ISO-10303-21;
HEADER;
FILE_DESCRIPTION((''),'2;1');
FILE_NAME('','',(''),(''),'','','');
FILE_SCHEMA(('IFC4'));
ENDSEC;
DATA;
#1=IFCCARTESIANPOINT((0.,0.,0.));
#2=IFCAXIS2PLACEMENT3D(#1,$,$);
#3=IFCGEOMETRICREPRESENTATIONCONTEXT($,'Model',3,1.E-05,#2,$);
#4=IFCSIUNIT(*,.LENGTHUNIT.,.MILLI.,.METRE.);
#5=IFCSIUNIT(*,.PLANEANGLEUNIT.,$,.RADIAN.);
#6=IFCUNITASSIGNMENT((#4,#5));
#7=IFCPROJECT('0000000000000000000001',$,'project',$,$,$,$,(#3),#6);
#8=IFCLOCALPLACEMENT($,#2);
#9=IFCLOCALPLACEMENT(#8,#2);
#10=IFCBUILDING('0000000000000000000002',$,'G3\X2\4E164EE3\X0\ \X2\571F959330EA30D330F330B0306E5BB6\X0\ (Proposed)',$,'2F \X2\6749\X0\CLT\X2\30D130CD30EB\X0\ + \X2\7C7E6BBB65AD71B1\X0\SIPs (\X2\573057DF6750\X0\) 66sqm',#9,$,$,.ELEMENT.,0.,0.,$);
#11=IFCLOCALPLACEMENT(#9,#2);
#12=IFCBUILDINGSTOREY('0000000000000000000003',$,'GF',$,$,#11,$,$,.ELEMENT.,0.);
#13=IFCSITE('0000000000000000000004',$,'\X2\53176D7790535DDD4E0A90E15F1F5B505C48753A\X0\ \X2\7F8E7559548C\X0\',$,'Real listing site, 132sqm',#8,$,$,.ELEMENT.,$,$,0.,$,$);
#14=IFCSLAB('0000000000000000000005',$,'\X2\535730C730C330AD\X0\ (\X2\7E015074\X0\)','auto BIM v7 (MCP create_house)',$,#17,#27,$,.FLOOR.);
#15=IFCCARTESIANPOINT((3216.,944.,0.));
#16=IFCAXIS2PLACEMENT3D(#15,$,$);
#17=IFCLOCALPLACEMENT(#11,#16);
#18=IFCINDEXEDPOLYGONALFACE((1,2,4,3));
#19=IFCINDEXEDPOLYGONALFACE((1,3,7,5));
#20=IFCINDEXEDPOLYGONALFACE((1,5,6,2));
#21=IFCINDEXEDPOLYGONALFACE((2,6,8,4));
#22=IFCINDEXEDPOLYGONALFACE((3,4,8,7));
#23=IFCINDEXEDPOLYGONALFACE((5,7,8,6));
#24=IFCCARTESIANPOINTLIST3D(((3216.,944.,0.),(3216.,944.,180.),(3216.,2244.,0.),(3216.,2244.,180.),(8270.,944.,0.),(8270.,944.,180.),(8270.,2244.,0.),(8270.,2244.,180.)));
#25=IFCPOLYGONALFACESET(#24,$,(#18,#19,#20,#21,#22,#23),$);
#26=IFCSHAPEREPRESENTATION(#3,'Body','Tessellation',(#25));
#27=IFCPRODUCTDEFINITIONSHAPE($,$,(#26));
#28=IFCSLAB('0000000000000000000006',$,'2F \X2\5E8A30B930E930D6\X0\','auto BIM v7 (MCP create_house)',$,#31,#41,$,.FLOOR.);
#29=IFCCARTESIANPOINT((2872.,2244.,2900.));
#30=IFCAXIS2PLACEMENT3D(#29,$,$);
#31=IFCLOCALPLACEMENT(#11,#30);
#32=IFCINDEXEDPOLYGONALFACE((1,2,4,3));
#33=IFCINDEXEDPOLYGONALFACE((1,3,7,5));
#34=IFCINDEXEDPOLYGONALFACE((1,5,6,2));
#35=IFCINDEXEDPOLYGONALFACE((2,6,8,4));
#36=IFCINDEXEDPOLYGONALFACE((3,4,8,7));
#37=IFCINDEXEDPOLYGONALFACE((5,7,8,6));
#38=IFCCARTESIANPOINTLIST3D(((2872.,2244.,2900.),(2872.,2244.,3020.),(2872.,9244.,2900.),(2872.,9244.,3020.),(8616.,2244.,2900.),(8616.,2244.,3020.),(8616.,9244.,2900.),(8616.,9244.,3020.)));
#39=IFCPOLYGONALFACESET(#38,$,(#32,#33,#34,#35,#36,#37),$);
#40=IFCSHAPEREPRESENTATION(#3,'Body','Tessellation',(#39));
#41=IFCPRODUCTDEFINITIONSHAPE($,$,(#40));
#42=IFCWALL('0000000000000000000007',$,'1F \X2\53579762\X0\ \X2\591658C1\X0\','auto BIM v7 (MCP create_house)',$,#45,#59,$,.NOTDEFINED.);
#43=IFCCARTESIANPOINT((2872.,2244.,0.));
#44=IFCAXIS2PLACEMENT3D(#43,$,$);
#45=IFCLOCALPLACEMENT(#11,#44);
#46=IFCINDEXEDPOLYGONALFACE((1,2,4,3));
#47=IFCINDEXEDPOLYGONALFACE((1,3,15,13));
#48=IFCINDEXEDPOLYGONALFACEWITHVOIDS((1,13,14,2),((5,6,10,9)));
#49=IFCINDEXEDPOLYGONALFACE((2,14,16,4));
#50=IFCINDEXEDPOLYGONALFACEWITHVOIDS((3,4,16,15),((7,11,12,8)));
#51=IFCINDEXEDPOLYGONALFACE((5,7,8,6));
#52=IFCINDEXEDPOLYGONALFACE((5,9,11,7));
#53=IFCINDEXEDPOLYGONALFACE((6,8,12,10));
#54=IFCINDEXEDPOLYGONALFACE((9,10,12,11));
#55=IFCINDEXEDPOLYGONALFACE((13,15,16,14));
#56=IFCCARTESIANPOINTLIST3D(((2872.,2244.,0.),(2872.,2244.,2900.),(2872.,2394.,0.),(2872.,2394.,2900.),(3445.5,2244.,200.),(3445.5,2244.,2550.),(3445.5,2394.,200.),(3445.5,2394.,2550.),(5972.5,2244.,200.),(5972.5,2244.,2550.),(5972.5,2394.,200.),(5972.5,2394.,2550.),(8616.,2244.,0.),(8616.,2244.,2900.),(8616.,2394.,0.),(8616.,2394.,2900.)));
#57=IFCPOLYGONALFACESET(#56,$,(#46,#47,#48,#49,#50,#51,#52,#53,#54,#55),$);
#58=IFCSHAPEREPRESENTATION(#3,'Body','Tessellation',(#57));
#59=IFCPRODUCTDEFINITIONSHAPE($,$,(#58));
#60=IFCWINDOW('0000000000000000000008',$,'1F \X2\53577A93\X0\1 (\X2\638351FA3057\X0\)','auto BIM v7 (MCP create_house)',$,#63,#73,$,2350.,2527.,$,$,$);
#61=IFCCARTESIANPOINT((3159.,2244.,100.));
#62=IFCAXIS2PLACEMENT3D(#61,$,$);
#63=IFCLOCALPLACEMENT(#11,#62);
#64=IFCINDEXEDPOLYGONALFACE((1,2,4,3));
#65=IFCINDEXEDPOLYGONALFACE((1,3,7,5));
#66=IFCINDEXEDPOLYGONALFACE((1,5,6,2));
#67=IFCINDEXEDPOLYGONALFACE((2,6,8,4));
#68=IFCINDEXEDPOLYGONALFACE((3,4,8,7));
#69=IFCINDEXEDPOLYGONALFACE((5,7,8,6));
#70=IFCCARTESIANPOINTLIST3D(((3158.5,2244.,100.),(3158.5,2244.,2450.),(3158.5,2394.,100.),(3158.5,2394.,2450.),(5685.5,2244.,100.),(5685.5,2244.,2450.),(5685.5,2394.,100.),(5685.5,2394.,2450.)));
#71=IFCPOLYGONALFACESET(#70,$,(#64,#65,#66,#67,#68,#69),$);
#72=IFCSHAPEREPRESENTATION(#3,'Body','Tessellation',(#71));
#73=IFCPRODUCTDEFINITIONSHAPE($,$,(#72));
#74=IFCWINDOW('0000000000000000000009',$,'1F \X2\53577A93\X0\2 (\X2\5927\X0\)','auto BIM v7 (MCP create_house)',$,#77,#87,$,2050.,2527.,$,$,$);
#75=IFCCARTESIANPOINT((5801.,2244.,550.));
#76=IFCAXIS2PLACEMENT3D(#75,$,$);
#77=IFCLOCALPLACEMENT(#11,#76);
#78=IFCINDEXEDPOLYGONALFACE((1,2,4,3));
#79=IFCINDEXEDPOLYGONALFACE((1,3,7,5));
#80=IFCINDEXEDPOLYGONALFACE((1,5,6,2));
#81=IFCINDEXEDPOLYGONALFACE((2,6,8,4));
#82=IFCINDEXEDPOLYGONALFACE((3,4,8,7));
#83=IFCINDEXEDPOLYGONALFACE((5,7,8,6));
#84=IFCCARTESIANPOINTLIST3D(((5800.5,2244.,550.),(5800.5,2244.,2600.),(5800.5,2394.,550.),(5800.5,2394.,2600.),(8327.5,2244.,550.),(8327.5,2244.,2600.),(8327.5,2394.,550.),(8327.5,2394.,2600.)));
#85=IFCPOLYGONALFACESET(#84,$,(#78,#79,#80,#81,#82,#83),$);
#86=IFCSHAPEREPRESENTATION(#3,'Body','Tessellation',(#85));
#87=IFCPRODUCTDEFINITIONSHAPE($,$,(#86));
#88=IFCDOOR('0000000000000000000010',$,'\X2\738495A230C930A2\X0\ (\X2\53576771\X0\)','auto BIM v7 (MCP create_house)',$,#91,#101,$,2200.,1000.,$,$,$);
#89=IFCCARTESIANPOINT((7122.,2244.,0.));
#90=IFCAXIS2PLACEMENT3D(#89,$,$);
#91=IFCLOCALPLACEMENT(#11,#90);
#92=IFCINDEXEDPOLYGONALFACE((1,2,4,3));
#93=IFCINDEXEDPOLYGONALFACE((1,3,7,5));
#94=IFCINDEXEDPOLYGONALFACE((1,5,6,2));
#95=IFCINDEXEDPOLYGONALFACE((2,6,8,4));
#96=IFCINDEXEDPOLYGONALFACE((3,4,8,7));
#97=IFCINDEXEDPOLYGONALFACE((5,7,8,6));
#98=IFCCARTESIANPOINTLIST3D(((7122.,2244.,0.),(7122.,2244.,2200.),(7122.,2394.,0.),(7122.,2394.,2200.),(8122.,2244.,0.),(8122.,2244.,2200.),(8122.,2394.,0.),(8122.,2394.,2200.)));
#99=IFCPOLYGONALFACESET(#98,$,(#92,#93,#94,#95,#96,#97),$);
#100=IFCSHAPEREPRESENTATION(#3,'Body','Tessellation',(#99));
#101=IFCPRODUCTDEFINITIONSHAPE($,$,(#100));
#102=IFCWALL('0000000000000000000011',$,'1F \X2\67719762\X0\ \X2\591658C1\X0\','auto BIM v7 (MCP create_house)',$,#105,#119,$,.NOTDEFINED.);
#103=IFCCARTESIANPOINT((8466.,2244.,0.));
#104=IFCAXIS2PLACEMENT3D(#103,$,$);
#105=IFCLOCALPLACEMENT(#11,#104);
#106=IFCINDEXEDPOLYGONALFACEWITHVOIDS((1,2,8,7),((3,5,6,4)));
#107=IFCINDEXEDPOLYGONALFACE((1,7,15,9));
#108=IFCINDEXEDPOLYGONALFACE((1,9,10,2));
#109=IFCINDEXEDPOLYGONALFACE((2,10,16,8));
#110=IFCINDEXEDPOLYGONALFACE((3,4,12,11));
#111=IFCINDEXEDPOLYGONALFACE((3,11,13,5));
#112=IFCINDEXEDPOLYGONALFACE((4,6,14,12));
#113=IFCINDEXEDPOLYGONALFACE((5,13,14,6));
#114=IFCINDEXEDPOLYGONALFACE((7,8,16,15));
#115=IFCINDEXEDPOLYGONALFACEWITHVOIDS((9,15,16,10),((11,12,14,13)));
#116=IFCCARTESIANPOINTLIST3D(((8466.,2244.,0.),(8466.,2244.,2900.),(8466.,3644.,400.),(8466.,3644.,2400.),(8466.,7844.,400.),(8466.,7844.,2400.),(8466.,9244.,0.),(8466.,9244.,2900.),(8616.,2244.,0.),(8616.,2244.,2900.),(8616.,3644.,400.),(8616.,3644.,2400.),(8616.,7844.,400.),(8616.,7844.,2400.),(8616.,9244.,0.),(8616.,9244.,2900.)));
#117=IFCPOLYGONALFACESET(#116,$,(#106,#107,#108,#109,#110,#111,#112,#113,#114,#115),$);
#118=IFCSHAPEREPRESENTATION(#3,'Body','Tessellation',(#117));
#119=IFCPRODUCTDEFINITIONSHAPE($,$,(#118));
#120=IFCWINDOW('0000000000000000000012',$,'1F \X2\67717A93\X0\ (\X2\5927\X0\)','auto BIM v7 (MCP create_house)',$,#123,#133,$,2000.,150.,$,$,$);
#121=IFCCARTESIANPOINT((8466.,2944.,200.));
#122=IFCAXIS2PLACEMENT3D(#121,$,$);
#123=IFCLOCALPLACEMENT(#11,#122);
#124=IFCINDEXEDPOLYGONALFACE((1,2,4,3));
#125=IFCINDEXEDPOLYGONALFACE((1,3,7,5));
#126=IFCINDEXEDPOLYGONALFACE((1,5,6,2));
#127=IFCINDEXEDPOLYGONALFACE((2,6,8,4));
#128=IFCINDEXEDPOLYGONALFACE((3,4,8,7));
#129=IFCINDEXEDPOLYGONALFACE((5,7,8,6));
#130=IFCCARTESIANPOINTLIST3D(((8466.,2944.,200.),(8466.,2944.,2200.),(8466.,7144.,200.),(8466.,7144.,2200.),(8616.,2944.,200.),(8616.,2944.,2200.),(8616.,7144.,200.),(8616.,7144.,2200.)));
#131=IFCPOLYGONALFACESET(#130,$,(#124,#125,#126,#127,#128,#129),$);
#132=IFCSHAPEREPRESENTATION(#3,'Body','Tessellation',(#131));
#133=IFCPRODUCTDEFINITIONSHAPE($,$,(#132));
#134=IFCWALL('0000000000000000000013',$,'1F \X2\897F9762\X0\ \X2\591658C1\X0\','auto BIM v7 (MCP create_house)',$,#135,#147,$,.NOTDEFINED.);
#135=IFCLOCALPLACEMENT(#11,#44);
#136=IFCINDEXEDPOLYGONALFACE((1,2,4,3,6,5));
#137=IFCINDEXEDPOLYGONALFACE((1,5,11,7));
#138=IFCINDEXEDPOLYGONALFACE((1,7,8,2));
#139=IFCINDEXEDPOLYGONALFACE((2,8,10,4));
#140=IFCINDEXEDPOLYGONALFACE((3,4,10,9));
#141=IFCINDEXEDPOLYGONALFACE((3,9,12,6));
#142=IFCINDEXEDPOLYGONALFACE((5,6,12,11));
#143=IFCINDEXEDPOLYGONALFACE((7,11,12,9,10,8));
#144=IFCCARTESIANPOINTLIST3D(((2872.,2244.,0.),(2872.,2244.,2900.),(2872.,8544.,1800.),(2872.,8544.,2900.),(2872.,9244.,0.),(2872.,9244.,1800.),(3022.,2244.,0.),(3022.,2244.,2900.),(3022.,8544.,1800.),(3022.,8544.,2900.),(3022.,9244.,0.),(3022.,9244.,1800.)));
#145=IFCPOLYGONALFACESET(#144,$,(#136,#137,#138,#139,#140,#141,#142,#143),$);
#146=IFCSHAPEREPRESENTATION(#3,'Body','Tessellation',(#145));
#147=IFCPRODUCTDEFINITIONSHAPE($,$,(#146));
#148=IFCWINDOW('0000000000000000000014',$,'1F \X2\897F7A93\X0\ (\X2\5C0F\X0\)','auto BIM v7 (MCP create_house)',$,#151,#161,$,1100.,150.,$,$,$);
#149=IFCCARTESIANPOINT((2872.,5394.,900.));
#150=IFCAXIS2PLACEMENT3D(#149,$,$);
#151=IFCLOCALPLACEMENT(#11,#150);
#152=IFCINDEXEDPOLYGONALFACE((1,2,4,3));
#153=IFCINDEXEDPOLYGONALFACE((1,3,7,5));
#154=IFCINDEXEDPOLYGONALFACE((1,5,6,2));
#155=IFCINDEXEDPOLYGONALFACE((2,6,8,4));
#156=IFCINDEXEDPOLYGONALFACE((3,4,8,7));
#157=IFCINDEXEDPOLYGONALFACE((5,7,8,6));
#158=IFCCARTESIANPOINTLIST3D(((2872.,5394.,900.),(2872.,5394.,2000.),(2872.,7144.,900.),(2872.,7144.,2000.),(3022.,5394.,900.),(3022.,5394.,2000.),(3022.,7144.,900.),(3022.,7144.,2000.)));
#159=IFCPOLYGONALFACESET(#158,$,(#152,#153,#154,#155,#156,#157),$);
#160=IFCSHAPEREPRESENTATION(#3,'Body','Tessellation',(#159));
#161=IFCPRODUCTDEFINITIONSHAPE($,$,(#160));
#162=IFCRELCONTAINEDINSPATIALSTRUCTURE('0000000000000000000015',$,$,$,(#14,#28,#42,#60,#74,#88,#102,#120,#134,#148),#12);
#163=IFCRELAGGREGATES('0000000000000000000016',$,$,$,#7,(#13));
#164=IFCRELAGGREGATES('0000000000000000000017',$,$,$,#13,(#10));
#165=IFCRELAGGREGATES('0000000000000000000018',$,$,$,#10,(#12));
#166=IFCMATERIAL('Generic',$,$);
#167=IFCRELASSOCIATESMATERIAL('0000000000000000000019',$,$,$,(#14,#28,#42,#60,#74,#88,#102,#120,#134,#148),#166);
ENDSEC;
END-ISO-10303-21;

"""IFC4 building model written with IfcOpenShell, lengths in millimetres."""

from ifc_helpers import new_model, si_unit, frame, frame_2d, origin, place, context, project, spatial, rectangle, extrude, material, element, fill, save


model = new_model("IFC4")

# Units and contexts
model_context = context("Model", 3, precision=1e-05, world=origin())
ifc_project = project(units=[si_unit("LENGTHUNIT", "METRE", prefix="MILLI"), si_unit("PLANEANGLEUNIT", "RADIAN")], contexts=[model_context])

# Site, building, storey
site_placement = place(None, origin())
site = spatial("IfcSite", under=ifc_project, at=site_placement, Name="北海道川上郡弟子屈町 美留和", ObjectType="Real listing site, 132sqm", CompositionType="ELEMENT", RefElevation=0.0)
building_placement = place(site_placement, origin())
building = spatial("IfcBuilding", under=site, at=building_placement, Name="G3世代 土間リビングの家 (Proposed)", ObjectType="2F 杉CLTパネル + 籾殻断熱SIPs (地域材) 66sqm", CompositionType="ELEMENT", ElevationOfRefHeight=0.0, ElevationOfTerrain=0.0)
storey_placement = place(building_placement, origin())
storey = spatial("IfcBuildingStorey", under=building, at=storey_placement, Name="GF", CompositionType="ELEMENT", Elevation=0.0)

# Slabs
ifc_material = material(Name="Generic")
slab_1_placement = place(storey_placement, frame((3216.0, 944.0, 0.0)))
element("IfcSlab", 1, at=slab_1_placement, inside=storey, material=ifc_material, Name="南デッキ (縁側)", Description="auto BIM v7 (MCP create_house)", PredefinedType="FLOOR", context=model_context, shape_type="SweptSolid", body=[
    extrude(rectangle(XDim=5054.0, YDim=1300.0, at=frame_2d((2527.0, 650.0))), frame((3216.0, 944.0, 0.0)), (0.0, 0.0, 1.0), 180.0),
])
slab_2_placement = place(storey_placement, frame((2872.0, 2244.0, 2900.0)))
element("IfcSlab", 2, at=slab_2_placement, inside=storey, material=ifc_material, Name="2F 床スラブ", Description="auto BIM v7 (MCP create_house)", PredefinedType="FLOOR", context=model_context, shape_type="SweptSolid", body=[
    extrude(rectangle(XDim=5744.0, YDim=7000.0, at=frame_2d((2872.0, 3500.0))), frame((2872.0, 2244.0, 2900.0)), (0.0, 0.0, 1.0), 120.0),
])

# Wall, openings, windows, door
wall_1_placement = place(storey_placement, frame((2872.0, 2244.0, 0.0)))
wall_1 = element("IfcWall", 3, at=wall_1_placement, inside=storey, material=ifc_material, Name="1F 南面 外壁", Description="auto BIM v7 (MCP create_house)", PredefinedType="NOTDEFINED", context=model_context, shape_type="SweptSolid", body=[
    extrude(rectangle(XDim=5744.0, YDim=150.0, at=frame_2d((2872.0, 75.0))), frame((2872.0, 2244.0, 0.0)), (0.0, 0.0, 1.0), 2900.0),
])
opening_1_placement = place(storey_placement, frame((3159.0, 2244.0, 100.0)))
opening_1 = element("IfcOpeningElement", 4, at=opening_1_placement, cuts=wall_1, PredefinedType="NOTDEFINED", context=model_context, shape_type="SweptSolid", body=[
    extrude(rectangle(XDim=2527.0, YDim=150.0, at=frame_2d((1263.0, 75.0))), frame((3159.0, 2244.0, 100.0)), (0.0, 0.0, 1.0), 2350.0),
])
opening_2_placement = place(storey_placement, frame((5801.0, 2244.0, 550.0)))
opening_2 = element("IfcOpeningElement", 5, at=opening_2_placement, cuts=wall_1, PredefinedType="NOTDEFINED", context=model_context, shape_type="SweptSolid", body=[
    extrude(rectangle(XDim=2527.0, YDim=150.0, at=frame_2d((1263.0, 75.0))), frame((5801.0, 2244.0, 550.0)), (0.0, 0.0, 1.0), 2050.0),
])
opening_3_placement = place(storey_placement, frame((7122.0, 2244.0, 0.0)))
opening_3 = element("IfcOpeningElement", 6, at=opening_3_placement, cuts=wall_1, PredefinedType="NOTDEFINED", context=model_context, shape_type="SweptSolid", body=[
    extrude(rectangle(XDim=1000.0, YDim=150.0, at=frame_2d((500.0, 75.0))), frame((7122.0, 2244.0, 0.0)), (0.0, 0.0, 1.0), 2200.0),
])
window_1_placement = place(storey_placement, frame((3159.0, 2244.0, 100.0)))
window_1 = element("IfcWindow", 7, at=window_1_placement, inside=storey, material=ifc_material, Name="1F 南窓1 (掃出し)", Description="auto BIM v7 (MCP create_house)", OverallHeight=2350.0, OverallWidth=2527.0, context=model_context, shape_type="SweptSolid", body=[
    extrude(rectangle(XDim=2527.0, YDim=150.0, at=frame_2d((1263.0, 75.0))), frame((3159.0, 2244.0, 100.0)), (0.0, 0.0, 1.0), 2350.0),
])
fill(opening_1, window_1)
window_2_placement = place(storey_placement, frame((5801.0, 2244.0, 550.0)))
window_2 = element("IfcWindow", 8, at=window_2_placement, inside=storey, material=ifc_material, Name="1F 南窓2 (大)", Description="auto BIM v7 (MCP create_house)", OverallHeight=2050.0, OverallWidth=2527.0, context=model_context, shape_type="SweptSolid", body=[
    extrude(rectangle(XDim=2527.0, YDim=150.0, at=frame_2d((1263.0, 75.0))), frame((5801.0, 2244.0, 550.0)), (0.0, 0.0, 1.0), 2050.0),
])
fill(opening_2, window_2)
door_placement = place(storey_placement, frame((7122.0, 2244.0, 0.0)))
door = element("IfcDoor", 9, at=door_placement, inside=storey, material=ifc_material, Name="玄関ドア (南東)", Description="auto BIM v7 (MCP create_house)", OverallHeight=2200.0, OverallWidth=1000.0, context=model_context, shape_type="SweptSolid", body=[
    extrude(rectangle(XDim=1000.0, YDim=150.0, at=frame_2d((500.0, 75.0))), frame((7122.0, 2244.0, 0.0)), (0.0, 0.0, 1.0), 2200.0),
])
fill(opening_3, door)

# Walls, openings, windows
wall_2_placement = place(storey_placement, frame((8466.0, 2244.0, 0.0)))
wall_2 = element("IfcWall", 10, at=wall_2_placement, inside=storey, material=ifc_material, Name="1F 東面 外壁", Description="auto BIM v7 (MCP create_house)", PredefinedType="NOTDEFINED", context=model_context, shape_type="SweptSolid", body=[
    extrude(rectangle(XDim=150.0, YDim=7000.0, at=frame_2d((75.0, 3500.0))), frame((8466.0, 2244.0, 0.0)), (0.0, 0.0, 1.0), 2900.0),
])
opening_4_placement = place(storey_placement, frame((8466.0, 2944.0, 200.0)))
opening_4 = element("IfcOpeningElement", 11, at=opening_4_placement, cuts=wall_2, PredefinedType="NOTDEFINED", context=model_context, shape_type="SweptSolid", body=[
    extrude(rectangle(XDim=150.0, YDim=4200.0, at=frame_2d((75.0, 2100.0))), frame((8466.0, 2944.0, 200.0)), (0.0, 0.0, 1.0), 2000.0),
])
window_3_placement = place(storey_placement, frame((8466.0, 2944.0, 200.0)))
window_3 = element("IfcWindow", 12, at=window_3_placement, inside=storey, material=ifc_material, Name="1F 東窓 (大)", Description="auto BIM v7 (MCP create_house)", OverallHeight=2000.0, OverallWidth=150.0, context=model_context, shape_type="SweptSolid", body=[
    extrude(rectangle(XDim=150.0, YDim=4200.0, at=frame_2d((75.0, 2100.0))), frame((8466.0, 2944.0, 200.0)), (0.0, 0.0, 1.0), 2000.0),
])
fill(opening_4, window_3)
wall_3_placement = place(storey_placement, frame((2872.0, 2244.0, 0.0)))
wall_3 = element("IfcWall", 13, at=wall_3_placement, inside=storey, material=ifc_material, Name="1F 西面 外壁", Description="auto BIM v7 (MCP create_house)", PredefinedType="NOTDEFINED", context=model_context, shape_type="SweptSolid", body=[
    extrude(rectangle(XDim=150.0, YDim=7000.0, at=frame_2d((75.0, 3500.0))), frame((2872.0, 2244.0, 0.0)), (0.0, 0.0, 1.0), 2900.0),
])
opening_5_placement = place(storey_placement, frame((2872.0, 5394.0, 900.0)))
opening_5 = element("IfcOpeningElement", 14, at=opening_5_placement, cuts=wall_3, PredefinedType="NOTDEFINED", context=model_context, shape_type="SweptSolid", body=[
    extrude(rectangle(XDim=150.0, YDim=1750.0, at=frame_2d((75.0, 875.0))), frame((2872.0, 5394.0, 900.0)), (0.0, 0.0, 1.0), 1100.0),
])
window_4_placement = place(storey_placement, frame((2872.0, 5394.0, 900.0)))
window_4 = element("IfcWindow", 15, at=window_4_placement, inside=storey, material=ifc_material, Name="1F 西窓 (小)", Description="auto BIM v7 (MCP create_house)", OverallHeight=1100.0, OverallWidth=150.0, context=model_context, shape_type="SweptSolid", body=[
    extrude(rectangle(XDim=150.0, YDim=1750.0, at=frame_2d((75.0, 875.0))), frame((2872.0, 5394.0, 900.0)), (0.0, 0.0, 1.0), 1100.0),
])
fill(opening_5, window_4)

save(model, "model.ifc")
